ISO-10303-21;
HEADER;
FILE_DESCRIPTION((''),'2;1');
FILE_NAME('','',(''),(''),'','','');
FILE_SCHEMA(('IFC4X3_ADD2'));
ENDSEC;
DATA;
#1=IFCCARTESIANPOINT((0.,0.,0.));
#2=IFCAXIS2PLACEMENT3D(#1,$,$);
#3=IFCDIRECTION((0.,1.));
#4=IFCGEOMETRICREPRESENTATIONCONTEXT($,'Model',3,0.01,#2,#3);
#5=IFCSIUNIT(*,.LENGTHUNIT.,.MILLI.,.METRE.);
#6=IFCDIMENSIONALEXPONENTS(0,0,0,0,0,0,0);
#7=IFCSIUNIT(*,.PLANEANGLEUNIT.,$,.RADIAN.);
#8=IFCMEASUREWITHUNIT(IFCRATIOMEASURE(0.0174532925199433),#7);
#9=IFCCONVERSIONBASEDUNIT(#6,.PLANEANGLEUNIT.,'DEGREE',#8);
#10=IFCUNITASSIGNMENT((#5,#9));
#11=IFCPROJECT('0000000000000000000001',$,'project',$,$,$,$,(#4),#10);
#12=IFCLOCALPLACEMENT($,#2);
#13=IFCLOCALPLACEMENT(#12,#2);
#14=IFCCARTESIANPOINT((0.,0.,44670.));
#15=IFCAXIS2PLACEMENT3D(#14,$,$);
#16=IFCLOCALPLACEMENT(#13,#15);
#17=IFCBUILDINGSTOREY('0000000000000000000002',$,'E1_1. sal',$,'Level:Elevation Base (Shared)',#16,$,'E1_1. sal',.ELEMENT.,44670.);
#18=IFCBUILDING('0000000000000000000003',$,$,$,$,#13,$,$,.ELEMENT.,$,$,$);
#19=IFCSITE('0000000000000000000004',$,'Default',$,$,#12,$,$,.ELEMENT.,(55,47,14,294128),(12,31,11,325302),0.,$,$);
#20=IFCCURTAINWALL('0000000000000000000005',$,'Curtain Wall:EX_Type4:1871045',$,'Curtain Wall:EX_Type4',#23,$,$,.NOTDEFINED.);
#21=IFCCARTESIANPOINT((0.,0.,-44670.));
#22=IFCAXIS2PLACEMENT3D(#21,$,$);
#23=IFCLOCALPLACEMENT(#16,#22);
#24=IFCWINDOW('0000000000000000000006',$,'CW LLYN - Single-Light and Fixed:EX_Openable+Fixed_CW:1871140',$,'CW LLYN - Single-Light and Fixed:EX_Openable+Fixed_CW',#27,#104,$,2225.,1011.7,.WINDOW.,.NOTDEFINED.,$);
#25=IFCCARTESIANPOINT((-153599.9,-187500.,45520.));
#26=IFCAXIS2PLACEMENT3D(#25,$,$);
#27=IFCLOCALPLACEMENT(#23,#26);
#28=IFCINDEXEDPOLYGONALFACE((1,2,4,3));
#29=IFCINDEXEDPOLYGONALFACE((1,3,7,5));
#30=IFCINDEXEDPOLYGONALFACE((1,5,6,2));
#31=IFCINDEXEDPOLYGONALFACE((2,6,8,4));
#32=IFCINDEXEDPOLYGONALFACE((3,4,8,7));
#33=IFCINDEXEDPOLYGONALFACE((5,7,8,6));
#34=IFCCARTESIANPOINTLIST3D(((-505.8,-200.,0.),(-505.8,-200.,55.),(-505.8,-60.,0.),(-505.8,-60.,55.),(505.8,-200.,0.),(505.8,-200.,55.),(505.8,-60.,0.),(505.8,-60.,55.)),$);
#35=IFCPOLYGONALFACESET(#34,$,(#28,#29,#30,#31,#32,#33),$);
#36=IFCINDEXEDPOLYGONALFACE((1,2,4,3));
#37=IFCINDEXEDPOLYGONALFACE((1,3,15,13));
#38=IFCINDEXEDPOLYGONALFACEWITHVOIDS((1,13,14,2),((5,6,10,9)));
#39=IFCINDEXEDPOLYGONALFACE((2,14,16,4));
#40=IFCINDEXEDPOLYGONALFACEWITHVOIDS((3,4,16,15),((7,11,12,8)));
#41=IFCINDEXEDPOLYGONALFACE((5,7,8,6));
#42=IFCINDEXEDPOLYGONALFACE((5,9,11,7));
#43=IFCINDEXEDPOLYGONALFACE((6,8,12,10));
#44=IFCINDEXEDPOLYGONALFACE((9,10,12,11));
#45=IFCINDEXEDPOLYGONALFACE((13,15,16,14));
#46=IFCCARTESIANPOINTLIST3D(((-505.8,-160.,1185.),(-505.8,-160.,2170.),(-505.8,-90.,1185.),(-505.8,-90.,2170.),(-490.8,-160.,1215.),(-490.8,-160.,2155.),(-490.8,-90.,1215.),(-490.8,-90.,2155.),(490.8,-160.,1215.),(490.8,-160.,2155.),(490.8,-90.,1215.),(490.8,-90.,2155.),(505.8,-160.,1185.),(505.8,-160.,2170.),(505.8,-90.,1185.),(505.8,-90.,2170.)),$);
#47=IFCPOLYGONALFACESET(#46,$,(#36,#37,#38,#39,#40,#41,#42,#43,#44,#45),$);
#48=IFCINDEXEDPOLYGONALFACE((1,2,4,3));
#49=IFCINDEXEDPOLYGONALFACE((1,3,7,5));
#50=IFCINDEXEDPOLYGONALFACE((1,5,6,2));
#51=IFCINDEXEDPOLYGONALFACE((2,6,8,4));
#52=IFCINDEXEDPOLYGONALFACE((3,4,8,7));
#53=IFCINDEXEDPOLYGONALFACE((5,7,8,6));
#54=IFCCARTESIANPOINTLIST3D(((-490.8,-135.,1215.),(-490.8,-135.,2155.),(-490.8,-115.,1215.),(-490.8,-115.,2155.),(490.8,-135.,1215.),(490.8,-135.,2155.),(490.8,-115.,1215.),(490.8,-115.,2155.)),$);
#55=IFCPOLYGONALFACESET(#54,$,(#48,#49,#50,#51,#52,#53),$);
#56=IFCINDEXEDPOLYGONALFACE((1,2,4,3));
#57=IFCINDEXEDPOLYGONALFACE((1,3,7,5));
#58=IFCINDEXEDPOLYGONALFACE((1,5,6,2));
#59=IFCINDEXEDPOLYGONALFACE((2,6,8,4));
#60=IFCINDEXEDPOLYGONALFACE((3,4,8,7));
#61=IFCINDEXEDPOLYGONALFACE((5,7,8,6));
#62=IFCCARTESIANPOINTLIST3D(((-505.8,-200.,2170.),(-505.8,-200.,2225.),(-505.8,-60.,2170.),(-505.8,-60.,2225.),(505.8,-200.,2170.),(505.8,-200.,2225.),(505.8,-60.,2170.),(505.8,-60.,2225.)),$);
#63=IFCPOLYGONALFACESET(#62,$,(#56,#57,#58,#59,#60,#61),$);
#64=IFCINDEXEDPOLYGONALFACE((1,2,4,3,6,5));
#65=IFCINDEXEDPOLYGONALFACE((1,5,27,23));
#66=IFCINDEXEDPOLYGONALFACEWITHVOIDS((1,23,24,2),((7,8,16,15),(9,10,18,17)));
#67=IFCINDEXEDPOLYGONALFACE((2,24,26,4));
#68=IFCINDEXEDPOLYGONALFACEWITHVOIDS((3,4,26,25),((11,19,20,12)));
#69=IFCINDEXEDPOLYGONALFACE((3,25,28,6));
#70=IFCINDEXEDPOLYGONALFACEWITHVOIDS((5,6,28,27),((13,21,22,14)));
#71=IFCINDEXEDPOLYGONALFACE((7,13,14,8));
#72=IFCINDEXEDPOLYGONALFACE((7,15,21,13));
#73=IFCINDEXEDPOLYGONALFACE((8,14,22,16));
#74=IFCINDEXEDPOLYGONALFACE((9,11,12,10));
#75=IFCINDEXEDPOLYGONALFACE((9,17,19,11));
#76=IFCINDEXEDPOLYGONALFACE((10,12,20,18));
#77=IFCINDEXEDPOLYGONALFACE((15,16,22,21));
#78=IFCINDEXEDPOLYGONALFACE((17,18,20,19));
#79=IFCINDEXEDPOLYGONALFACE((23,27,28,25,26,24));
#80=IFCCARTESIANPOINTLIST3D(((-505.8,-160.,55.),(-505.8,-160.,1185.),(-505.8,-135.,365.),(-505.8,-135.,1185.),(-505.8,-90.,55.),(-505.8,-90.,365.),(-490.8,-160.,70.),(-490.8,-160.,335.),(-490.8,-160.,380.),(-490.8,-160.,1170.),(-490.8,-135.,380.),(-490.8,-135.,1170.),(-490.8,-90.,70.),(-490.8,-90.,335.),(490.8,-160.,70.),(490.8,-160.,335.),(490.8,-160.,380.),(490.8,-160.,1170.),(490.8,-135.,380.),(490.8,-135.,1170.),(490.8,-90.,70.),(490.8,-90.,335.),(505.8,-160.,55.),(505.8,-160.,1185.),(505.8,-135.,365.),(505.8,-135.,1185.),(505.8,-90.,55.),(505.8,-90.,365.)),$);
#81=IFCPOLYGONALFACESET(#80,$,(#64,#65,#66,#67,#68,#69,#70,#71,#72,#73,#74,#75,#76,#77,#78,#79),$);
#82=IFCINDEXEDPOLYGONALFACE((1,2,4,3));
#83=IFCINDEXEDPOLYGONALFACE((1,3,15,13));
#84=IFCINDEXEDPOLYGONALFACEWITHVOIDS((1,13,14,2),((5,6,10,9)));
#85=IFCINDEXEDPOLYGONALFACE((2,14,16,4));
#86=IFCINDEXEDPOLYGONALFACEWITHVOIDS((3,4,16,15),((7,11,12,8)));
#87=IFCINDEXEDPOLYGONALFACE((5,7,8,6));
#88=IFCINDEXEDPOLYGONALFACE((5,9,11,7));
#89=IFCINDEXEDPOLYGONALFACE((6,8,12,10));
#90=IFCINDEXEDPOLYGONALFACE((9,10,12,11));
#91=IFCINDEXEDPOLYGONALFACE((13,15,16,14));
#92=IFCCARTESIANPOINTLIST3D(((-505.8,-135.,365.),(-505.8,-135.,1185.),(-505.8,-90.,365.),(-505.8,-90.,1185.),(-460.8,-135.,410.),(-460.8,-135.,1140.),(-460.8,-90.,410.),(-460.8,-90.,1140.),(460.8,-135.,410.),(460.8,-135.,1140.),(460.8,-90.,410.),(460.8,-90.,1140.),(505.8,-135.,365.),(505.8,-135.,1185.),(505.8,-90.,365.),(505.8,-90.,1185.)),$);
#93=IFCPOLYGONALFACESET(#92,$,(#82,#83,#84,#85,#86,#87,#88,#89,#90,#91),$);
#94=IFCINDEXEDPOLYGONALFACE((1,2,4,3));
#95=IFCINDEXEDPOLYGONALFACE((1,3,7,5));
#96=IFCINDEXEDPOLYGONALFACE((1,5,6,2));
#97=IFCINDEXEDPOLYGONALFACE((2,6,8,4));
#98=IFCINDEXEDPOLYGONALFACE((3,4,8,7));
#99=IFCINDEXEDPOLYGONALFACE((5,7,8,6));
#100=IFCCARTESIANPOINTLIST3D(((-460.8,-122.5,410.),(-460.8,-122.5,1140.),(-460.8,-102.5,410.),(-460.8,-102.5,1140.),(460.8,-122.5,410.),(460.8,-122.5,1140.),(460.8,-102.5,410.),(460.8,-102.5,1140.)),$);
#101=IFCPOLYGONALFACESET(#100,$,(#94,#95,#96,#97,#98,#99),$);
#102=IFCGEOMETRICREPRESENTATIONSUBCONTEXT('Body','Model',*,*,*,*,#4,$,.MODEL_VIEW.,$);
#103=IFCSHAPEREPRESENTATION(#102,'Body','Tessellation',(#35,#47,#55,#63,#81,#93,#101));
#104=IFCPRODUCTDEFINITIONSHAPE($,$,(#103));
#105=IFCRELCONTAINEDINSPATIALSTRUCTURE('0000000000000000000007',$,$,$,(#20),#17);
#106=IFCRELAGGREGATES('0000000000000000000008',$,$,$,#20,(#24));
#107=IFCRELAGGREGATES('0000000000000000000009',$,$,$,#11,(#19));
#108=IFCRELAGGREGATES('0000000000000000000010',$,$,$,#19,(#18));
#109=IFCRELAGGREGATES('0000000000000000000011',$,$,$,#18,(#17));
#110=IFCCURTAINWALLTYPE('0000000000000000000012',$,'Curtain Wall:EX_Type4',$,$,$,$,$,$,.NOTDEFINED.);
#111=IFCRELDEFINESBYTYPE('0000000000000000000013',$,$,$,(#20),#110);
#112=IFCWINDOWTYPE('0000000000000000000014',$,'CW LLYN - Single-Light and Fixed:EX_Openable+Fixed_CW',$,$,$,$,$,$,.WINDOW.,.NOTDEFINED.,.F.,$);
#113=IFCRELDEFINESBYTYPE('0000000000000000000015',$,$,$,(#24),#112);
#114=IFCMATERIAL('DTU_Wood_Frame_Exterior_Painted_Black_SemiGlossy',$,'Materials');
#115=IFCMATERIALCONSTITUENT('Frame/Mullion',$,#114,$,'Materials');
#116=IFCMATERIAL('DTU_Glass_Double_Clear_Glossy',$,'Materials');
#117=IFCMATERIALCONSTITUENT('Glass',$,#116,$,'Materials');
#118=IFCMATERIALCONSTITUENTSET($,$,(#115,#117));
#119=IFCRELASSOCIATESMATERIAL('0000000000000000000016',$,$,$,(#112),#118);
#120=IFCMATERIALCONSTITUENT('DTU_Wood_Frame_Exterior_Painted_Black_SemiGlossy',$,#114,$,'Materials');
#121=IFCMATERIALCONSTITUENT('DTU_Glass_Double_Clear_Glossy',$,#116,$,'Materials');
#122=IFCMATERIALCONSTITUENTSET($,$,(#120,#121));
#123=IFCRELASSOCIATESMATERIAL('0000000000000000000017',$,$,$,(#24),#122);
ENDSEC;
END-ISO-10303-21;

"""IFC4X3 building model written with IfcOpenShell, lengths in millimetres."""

from ifc_helpers import new_model, entity, si_unit, converted_unit, direction, frame, frame_2d, origin, origin_2d_with_axis, place, context, subcontext, project, spatial, polyline, rectangle, outline, extrude, source, transform, mapped, material, constituent, constituent_set, type_object, type_shapes, element, aggregate, save


model = new_model("IFC4X3")

# Units and contexts
model_context = context("Model", 3, precision=0.01, world=origin(), true_north=direction((0.0, 1.0)))
body_context = subcontext(model_context, "Body", "Model", "MODEL_VIEW")
ifc_project = project(units=[si_unit("LENGTHUNIT", "METRE", prefix="MILLI"), converted_unit("PLANEANGLEUNIT", "DEGREE", entity("IfcRatioMeasure", 0.0174532925199433), si_unit("PLANEANGLEUNIT", "RADIAN"), dimensions=[0, 0, 0, 0, 0, 0, 0])], contexts=[model_context])

# Site, building, storey
site_placement = place(None, origin())
site = spatial("IfcSite", under=ifc_project, at=site_placement, Name="Default", CompositionType="ELEMENT", RefLatitude=(55, 47, 14, 294128), RefLongitude=(12, 31, 11, 325302), RefElevation=0.0)
building_placement = place(site_placement, origin())
building = spatial("IfcBuilding", under=site, at=building_placement, CompositionType="ELEMENT")
storey_placement = place(building_placement, frame((0.0, 0.0, 44670.0)))
storey = spatial("IfcBuildingStorey", under=building, at=storey_placement, Name="E1_1. sal", ObjectType="Level:Elevation Base (Shared)", LongName="E1_1. sal", CompositionType="ELEMENT", Elevation=44670.0)

# Curtain wall, window, openings
curtain_wall_type = type_object("IfcCurtainWallType", Name="Curtain Wall:EX_Type4", PredefinedType="NOTDEFINED")
curtain_wall_placement = place(storey_placement, frame((0.0, 0.0, -44670.0)))
curtain_wall = element("IfcCurtainWall", 1, at=curtain_wall_placement, inside=storey, type_object=curtain_wall_type, Name="Curtain Wall:EX_Type4:1871045", ObjectType="Curtain Wall:EX_Type4", PredefinedType="NOTDEFINED")
ifc_material_1 = material(Name="DTU_Wood_Frame_Exterior_Painted_Black_SemiGlossy", Category="Materials")
ifc_material_2 = material(Name="DTU_Glass_Double_Clear_Glossy", Category="Materials")
ifc_constituent_1 = constituent(ifc_material_1, Name="DTU_Wood_Frame_Exterior_Painted_Black_SemiGlossy", Category="Materials")
ifc_constituent_2 = constituent(ifc_material_2, Name="DTU_Glass_Double_Clear_Glossy", Category="Materials")
ifc_constituent_set_1 = constituent_set(constituents=[ifc_constituent_1, ifc_constituent_2])
ifc_constituent_3 = constituent(ifc_material_1, Name="Frame/Mullion", Category="Materials")
ifc_constituent_4 = constituent(ifc_material_2, Name="Glass", Category="Materials")
ifc_constituent_set_2 = constituent_set(constituents=[ifc_constituent_3, ifc_constituent_4])
window_type_1 = type_object("IfcWindowType", Name="CW LLYN - Single-Light and Fixed:EX_Openable+Fixed_CW", ParameterTakesPrecedence=False, PartitioningType="NOTDEFINED", PredefinedType="WINDOW", material=ifc_constituent_set_2)
shared_shape_1 = source(origin(), body_context, "Body", "SweptSolid", [
    extrude(rectangle(XDim=140.0, YDim=1011.7, at=origin_2d_with_axis()), frame((0.0, -130.0, 0.0), z_axis=(0.0, 0.0, 1.0), x_axis=(0.0, -1.0, 0.0)), (0.0, 0.0, 1.0), 55.0),
    extrude(outline(polyline([(-492.5, -505.8), (492.5, -505.8), (492.5, 505.8), (-492.5, 505.8), (-492.5, -505.8)]), holes=[polyline([(477.5, -490.8), (-462.5, -490.8), (-462.5, 490.8), (477.5, 490.8), (477.5, -490.8)])]), frame((0.0, -90.0, 1677.5), z_axis=(0.0, -1.0, 0.0), x_axis=(0.0, 0.0, 1.0)), (0.0, 0.0, 1.0), 70.0),
    extrude(rectangle(XDim=981.7, YDim=20.0, at=frame_2d((0.0, 0.0), x_axis=(1.0, 0.0))), frame((0.0, -125.0, 1215.0), z_axis=(0.0, 0.0, 1.0), x_axis=(-1.0, 0.0, 0.0)), (0.0, 0.0, 1.0), 940.0),
    extrude(rectangle(XDim=981.7, YDim=20.0, at=frame_2d((0.0, 0.0), x_axis=(1.0, 0.0))), frame((0.0, -125.0, 70.0), z_axis=(0.0, 0.0, 1.0), x_axis=(-1.0, 0.0, 0.0)), (0.0, 0.0, 1.0), 265.0),
    extrude(rectangle(XDim=140.0, YDim=1011.7, at=frame_2d((0.0, 0.0), x_axis=(1.0, 0.0))), frame((0.0, -130.0, 2170.0), z_axis=(0.0, 0.0, 1.0), x_axis=(0.0, -1.0, 0.0)), (0.0, 0.0, 1.0), 55.0),
    extrude(outline(polyline([(-38.3, -480.0), (31.7, -480.0), (31.7, 650.0), (6.7, 650.0), (6.7, -170.0), (-38.3, -170.0), (-38.3, -480.0)])), frame((505.8, -128.3, 535.0), z_axis=(-1.0, 0.0, 0.0), x_axis=(0.0, -1.0, 0.0)), (0.0, 0.0, 1.0), 1011.7),
    extrude(outline(polyline([(-410.0, -505.8), (410.0, -505.8), (410.0, 505.8), (-410.0, 505.8), (-410.0, -505.8)]), holes=[polyline([(-365.0, 460.8), (365.0, 460.8), (365.0, -460.8), (-365.0, -460.8), (-365.0, 460.8)])]), frame((0.0, -90.0, 775.0), z_axis=(0.0, -1.0, 0.0), x_axis=(0.0, 0.0, 1.0)), (0.0, 0.0, 1.0), 45.0),
    extrude(rectangle(XDim=921.7, YDim=20.0, at=frame_2d((0.0, 0.0), x_axis=(1.0, 0.0))), frame((0.0, -112.5, 410.0), z_axis=(0.0, 0.0, 1.0), x_axis=(-1.0, 0.0, 0.0)), (0.0, 0.0, 1.0), 730.0),
])
type_shapes(window_type_1, [shared_shape_1])
window_1_placement = place(curtain_wall_placement, frame((-153599.9, -187500.0, 45520.0)))
window_1 = element("IfcWindow", 2, at=window_1_placement, type_object=window_type_1, material=ifc_constituent_set_1, Name="CW LLYN - Single-Light and Fixed:EX_Openable+Fixed_CW:1871140", ObjectType="CW LLYN - Single-Light and Fixed:EX_Openable+Fixed_CW", OverallHeight=2225.0, OverallWidth=1011.7, PartitioningType="NOTDEFINED", PredefinedType="WINDOW", context=body_context, shape_type="MappedRepresentation", body=[
    mapped(shared_shape_1, transform((0.0, 0.0, 0.0), scale=1.0)),
])
opening_1_placement = place(curtain_wall_placement, frame((-153599.9, -187500.0, 90190.0), z_axis=(0.0, 0.0, 1.0), x_axis=(-1.0, 0.0, 0.0)))
opening_1 = element("IfcOpeningElement", 3, at=opening_1_placement, cuts=window_1, PredefinedType="OPENING", context=body_context, shape_type="SweptSolid", body=[
    extrude(rectangle(XDim=265.0, YDim=981.7, at=frame_2d((0.0, 0.0), x_axis=(1.0, 0.0))), frame((0.0, 160.0, -44467.5), z_axis=(0.0, -1.0, 0.0), x_axis=(0.0, 0.0, 1.0)), (0.0, 0.0, 1.0), 70.0),
])
opening_2_placement = place(curtain_wall_placement, frame((-153599.9, -187500.0, 90190.0), z_axis=(0.0, 0.0, 1.0), x_axis=(-1.0, 0.0, 0.0)))
opening_2 = element("IfcOpeningElement", 4, at=opening_2_placement, cuts=window_1, PredefinedType="OPENING", context=body_context, shape_type="SweptSolid", body=[
    extrude(rectangle(XDim=790.0, YDim=981.7, at=frame_2d((0.0, 0.0), x_axis=(1.0, 0.0))), frame((0.0, 135.0, -43895.0), z_axis=(0.0, 1.0, 0.0), x_axis=(0.0, 0.0, 1.0)), (0.0, 0.0, 1.0), 25.0),
])
aggregate(curtain_wall, [window_1, opening_1, opening_2])

save(model, "model.ifc")
